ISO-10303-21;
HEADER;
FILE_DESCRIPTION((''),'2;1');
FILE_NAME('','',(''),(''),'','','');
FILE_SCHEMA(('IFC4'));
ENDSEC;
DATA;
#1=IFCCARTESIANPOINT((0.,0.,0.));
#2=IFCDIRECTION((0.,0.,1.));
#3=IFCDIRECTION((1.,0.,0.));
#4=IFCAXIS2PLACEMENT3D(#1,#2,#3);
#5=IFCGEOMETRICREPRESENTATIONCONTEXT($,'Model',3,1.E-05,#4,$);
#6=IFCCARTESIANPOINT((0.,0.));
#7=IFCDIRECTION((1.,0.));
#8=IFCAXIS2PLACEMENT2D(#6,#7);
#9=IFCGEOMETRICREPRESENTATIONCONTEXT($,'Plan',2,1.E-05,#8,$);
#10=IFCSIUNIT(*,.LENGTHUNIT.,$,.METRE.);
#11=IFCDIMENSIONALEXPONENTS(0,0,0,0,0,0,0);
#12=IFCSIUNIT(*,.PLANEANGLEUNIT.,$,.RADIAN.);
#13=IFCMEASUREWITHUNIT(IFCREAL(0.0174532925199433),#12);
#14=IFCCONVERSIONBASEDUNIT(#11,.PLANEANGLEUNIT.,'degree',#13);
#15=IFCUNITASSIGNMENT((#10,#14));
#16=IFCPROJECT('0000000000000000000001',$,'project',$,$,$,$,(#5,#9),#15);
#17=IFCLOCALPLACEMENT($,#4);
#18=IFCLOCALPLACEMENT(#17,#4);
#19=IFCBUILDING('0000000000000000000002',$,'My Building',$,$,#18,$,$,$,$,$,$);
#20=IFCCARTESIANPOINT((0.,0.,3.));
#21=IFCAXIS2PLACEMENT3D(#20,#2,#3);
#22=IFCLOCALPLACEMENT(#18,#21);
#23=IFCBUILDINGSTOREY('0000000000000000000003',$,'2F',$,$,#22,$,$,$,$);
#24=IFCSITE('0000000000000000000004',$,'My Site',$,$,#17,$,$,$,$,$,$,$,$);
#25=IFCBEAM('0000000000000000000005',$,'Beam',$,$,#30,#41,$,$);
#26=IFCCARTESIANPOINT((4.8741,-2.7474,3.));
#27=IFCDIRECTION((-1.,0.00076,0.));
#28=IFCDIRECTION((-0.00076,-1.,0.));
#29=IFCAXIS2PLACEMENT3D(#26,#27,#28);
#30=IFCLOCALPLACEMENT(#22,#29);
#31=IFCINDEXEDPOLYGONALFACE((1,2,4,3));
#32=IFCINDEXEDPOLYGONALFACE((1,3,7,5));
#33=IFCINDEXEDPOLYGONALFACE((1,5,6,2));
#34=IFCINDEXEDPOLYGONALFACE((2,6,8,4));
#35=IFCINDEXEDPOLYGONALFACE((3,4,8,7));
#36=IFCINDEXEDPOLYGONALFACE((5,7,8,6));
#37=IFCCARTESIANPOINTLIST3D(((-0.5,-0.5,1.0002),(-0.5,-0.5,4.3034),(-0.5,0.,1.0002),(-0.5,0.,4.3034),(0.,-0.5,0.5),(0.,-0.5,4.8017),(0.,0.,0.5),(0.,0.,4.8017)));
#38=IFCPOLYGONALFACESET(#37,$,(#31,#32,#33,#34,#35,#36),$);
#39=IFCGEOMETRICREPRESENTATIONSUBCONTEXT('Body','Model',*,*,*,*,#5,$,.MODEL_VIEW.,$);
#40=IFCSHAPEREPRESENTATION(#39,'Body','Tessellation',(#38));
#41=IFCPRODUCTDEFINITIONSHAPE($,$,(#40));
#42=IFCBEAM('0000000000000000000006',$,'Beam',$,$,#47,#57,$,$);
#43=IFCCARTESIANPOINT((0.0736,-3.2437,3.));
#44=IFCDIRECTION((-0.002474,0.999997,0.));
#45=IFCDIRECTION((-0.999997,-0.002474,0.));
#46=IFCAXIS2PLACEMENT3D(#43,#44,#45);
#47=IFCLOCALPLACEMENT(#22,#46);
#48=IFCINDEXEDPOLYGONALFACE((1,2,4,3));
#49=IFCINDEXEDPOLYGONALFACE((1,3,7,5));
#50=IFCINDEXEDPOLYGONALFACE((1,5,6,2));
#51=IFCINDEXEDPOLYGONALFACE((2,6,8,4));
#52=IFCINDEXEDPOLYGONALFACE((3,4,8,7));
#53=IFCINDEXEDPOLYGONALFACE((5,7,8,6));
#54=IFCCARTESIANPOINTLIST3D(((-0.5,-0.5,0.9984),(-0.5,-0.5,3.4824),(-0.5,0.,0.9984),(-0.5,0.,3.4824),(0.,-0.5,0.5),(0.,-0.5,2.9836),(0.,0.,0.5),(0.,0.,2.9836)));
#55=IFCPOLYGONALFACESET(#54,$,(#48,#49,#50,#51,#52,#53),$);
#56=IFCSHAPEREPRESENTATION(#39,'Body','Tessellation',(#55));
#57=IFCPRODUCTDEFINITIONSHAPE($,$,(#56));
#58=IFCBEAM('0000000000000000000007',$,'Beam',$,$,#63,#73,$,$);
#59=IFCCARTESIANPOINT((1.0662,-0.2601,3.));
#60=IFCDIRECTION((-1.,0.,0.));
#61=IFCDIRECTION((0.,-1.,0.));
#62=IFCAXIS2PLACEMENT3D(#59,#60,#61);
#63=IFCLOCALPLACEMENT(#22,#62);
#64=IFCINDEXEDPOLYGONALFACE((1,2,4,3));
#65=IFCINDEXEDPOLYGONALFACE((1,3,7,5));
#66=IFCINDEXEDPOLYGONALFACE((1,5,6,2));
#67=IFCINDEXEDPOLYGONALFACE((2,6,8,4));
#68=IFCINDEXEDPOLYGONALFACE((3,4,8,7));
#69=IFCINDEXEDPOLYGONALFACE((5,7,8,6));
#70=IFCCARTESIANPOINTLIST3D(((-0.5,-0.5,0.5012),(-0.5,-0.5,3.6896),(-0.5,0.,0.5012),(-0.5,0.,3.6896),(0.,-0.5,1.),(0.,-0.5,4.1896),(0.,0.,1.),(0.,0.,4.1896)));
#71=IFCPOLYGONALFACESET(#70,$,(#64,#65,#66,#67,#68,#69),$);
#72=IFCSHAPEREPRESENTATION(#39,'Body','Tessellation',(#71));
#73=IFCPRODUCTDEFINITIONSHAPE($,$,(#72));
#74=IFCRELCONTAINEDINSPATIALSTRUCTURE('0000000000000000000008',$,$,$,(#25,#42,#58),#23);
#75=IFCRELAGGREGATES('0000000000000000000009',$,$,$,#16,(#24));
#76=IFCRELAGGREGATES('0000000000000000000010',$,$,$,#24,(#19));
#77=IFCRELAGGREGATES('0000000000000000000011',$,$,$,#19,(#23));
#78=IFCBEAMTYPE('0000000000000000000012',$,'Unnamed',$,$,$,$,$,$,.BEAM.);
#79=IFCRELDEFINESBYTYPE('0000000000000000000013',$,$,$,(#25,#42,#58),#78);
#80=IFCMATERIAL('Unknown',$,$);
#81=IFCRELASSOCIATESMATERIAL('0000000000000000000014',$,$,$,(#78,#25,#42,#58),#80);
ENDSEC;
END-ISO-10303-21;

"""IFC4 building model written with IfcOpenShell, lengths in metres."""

from ifc_helpers import new_model, entity, si_unit, converted_unit, frame, origin_with_axes, origin_2d_with_axis, place, context, subcontext, project, spatial, rectangle, extrude, clip, halfspace, material, material_profile, profile_set, profile_usage, type_object, element, save


model = new_model("IFC4")

# Units and contexts
model_context = context("Model", 3, precision=1e-05, world=origin_with_axes())
plan_context = context("Plan", 2, precision=1e-05, world=origin_2d_with_axis())
body_context_1 = subcontext(model_context, "Body", "Model", "MODEL_VIEW")
ifc_project = project(units=[si_unit("LENGTHUNIT", "METRE"), converted_unit("PLANEANGLEUNIT", "degree", entity("IfcReal", 0.0174532925199433), si_unit("PLANEANGLEUNIT", "RADIAN"), dimensions=[0, 0, 0, 0, 0, 0, 0])], contexts=[model_context, plan_context])

# Site, building, storey
site_placement = place(None, origin_with_axes())
site = spatial("IfcSite", under=ifc_project, at=site_placement, Name="My Site")
building_placement = place(site_placement, origin_with_axes())
building = spatial("IfcBuilding", under=site, at=building_placement, Name="My Building")
storey_placement = place(building_placement, frame((0.0, 0.0, 3.0), z_axis=(0.0, 0.0, 1.0), x_axis=(1.0, 0.0, 0.0)))
storey = spatial("IfcBuildingStorey", under=building, at=storey_placement, Name="2F")

# Shared definitions
ifc_material = material(Name="Unknown")

# Beams
ifc_material_profile_1 = material_profile(ifc_material, rectangle(XDim=0.5, YDim=0.5))
ifc_profile_set_1 = profile_set([ifc_material_profile_1])
ifc_profile_usage_1 = profile_usage(ifc_profile_set_1, cardinal=7)
beam_type = type_object("IfcBeamType", Name="Unnamed", PredefinedType="BEAM", material=ifc_profile_set_1)
beam_1_placement = place(storey_placement, frame((4.8741, -2.7474, 3.0), z_axis=(-1.0, 0.00076, 0.0), x_axis=(-0.00076, -1.0, 0.0)))
element("IfcBeam", 1, at=beam_1_placement, inside=storey, type_object=beam_type, material=ifc_profile_usage_1, Name="Beam", context=body_context_1, shape_type="Clipping", body=[
    clip(clip(extrude(rectangle(XDim=0.5, YDim=0.5), frame((-0.25, -0.25, 0.0), z_axis=(0.0, 0.0, 1.0), x_axis=(1.0, 0.0, 0.0)), (0.0, 0.0, 1.0), 5.3017), halfspace(frame((0.0, -6.0, 4.8017), z_axis=(-0.705963, 0.0, 0.708249), x_axis=(0.0, 1.0, 0.0)), False)), halfspace(frame((0.0, -6.0, 0.5), z_axis=(-0.707281, 0.0, -0.706933), x_axis=(0.0, 1.0, 0.0)), False)),
])
ifc_profile_usage_2 = profile_usage(ifc_profile_set_1, cardinal=7)
beam_2_placement = place(storey_placement, frame((0.0736, -3.2437, 3.0), z_axis=(-0.002474, 0.999997, 0.0), x_axis=(-0.999997, -0.002474, 0.0)))
element("IfcBeam", 2, at=beam_2_placement, inside=storey, type_object=beam_type, material=ifc_profile_usage_2, Name="Beam", context=body_context_1, shape_type="Clipping", body=[
    clip(clip(extrude(rectangle(XDim=0.5, YDim=0.5), frame((-0.25, -0.25, 0.0), z_axis=(0.0, 0.0, 1.0), x_axis=(1.0, 0.0, 0.0)), (0.0, 0.0, 1.0), 3.9836), halfspace(frame((-0.5, -6.0, 3.4824), z_axis=(0.706232, 0.0, 0.707981), x_axis=(0.0, -1.0, 0.0)), False)), halfspace(frame((0.0, -6.0, 0.5), z_axis=(-0.705962, 0.0, -0.708249), x_axis=(0.0, 1.0, 0.0)), False)),
])
ifc_profile_usage_3 = profile_usage(ifc_profile_set_1, cardinal=7)
beam_3_placement = place(storey_placement, frame((1.0662, -0.2601, 3.0), z_axis=(-1.0, 0.0, 0.0), x_axis=(0.0, -1.0, 0.0)))
element("IfcBeam", 3, at=beam_3_placement, inside=storey, type_object=beam_type, material=ifc_profile_usage_3, Name="Beam", context=body_context_1, shape_type="Clipping", body=[
    clip(clip(extrude(rectangle(XDim=0.5, YDim=0.5), frame((-0.25, -0.25, 0.0), z_axis=(0.0, 0.0, 1.0), x_axis=(1.0, 0.0, 0.0)), (0.0, 0.0, 1.0), 4.1896), halfspace(frame((0.0, -6.0, 4.1896), z_axis=(-0.707107, 0.0, 0.707107), x_axis=(0.0, 1.0, 0.0)), False)), halfspace(frame((-0.5, -6.0, 0.5012), z_axis=(0.706232, 0.0, -0.707981), x_axis=(0.0, -1.0, 0.0)), False)),
])

save(model, "model.ifc")
